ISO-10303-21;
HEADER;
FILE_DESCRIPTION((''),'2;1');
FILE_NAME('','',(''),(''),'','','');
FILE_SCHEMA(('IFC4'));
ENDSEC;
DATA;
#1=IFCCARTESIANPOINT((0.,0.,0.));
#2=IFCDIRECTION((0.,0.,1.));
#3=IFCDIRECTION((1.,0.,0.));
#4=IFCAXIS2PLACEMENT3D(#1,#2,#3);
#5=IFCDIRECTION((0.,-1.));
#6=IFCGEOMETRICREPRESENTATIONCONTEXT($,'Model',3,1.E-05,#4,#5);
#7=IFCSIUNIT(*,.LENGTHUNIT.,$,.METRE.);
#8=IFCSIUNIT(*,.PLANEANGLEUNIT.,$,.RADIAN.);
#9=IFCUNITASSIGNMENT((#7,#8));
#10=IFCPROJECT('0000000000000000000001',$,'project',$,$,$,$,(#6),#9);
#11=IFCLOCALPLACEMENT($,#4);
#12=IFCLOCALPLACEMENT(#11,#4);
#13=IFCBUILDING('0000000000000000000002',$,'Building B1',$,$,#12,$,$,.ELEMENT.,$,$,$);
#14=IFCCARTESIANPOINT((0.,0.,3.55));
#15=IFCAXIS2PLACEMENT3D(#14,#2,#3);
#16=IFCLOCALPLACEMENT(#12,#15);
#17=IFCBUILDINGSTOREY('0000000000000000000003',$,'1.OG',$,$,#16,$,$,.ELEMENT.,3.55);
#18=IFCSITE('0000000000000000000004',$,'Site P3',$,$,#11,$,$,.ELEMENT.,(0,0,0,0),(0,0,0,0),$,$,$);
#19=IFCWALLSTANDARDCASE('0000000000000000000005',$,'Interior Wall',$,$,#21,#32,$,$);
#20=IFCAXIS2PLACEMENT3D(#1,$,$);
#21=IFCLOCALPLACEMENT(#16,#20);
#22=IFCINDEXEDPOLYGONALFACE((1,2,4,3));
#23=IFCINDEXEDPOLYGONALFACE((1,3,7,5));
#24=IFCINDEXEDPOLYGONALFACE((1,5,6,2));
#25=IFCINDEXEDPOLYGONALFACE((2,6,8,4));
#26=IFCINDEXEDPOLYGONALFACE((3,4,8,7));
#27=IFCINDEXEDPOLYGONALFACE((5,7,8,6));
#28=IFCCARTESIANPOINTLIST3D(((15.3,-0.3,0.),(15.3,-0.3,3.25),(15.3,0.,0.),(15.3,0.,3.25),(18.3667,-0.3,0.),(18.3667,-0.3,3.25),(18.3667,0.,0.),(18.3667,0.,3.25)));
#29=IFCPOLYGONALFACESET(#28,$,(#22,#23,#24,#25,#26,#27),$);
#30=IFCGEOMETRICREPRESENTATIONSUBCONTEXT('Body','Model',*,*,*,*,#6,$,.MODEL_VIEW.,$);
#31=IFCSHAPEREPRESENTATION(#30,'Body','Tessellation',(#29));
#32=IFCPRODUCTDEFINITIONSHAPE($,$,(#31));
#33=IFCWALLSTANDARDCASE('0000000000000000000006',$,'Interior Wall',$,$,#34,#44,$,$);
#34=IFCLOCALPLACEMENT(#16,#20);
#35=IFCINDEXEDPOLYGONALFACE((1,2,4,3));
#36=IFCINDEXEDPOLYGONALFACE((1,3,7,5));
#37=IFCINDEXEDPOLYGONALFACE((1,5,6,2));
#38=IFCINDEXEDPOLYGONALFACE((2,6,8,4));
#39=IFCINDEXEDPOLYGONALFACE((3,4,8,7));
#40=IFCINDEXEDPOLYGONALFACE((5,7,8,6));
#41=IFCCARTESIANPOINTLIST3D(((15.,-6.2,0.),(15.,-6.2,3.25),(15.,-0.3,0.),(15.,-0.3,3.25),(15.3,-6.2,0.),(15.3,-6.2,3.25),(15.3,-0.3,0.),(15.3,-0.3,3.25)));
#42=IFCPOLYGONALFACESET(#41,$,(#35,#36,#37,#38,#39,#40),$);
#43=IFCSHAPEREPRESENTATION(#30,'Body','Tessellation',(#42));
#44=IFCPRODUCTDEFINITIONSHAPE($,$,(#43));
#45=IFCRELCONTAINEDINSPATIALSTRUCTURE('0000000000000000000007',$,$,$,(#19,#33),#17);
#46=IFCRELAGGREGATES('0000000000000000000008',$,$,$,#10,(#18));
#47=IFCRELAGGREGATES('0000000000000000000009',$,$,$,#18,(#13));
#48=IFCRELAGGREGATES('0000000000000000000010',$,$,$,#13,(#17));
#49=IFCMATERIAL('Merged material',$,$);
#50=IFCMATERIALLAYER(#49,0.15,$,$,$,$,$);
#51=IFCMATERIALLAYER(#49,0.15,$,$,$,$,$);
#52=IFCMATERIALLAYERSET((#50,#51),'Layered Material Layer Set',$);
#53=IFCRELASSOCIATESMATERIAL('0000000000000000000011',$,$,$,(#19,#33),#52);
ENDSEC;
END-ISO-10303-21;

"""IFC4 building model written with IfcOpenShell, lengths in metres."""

from ifc_helpers import new_model, si_unit, direction, frame, origin_with_axes, place, context, subcontext, project, spatial, polyline, outline, extrude, material, layer, layer_set, layer_usage, element, save


model = new_model("IFC4")

# Units and contexts
model_context = context("Model", 3, precision=1e-05, world=origin_with_axes(), true_north=direction((0.0, -1.0)))
body_context = subcontext(model_context, "Body", "Model", "MODEL_VIEW")
ifc_project = project(units=[si_unit("LENGTHUNIT", "METRE"), si_unit("PLANEANGLEUNIT", "RADIAN")], contexts=[model_context])

# Site, building, storey
site_placement = place(None, origin_with_axes())
site = spatial("IfcSite", under=ifc_project, at=site_placement, Name="Site P3", CompositionType="ELEMENT", RefLatitude=(0, 0, 0, 0), RefLongitude=(0, 0, 0, 0))
building_placement = place(site_placement, origin_with_axes())
building = spatial("IfcBuilding", under=site, at=building_placement, Name="Building B1", CompositionType="ELEMENT")
storey_placement = place(building_placement, frame((0.0, 0.0, 3.55), z_axis=(0.0, 0.0, 1.0), x_axis=(1.0, 0.0, 0.0)))
storey = spatial("IfcBuildingStorey", under=building, at=storey_placement, Name="1.OG", CompositionType="ELEMENT", Elevation=3.55)

# Shared definitions
ifc_material = material(Name="Merged material")

# Shared definitions
ifc_layer_1 = layer(ifc_material, 0.15)
ifc_layer_2 = layer(ifc_material, 0.15)
ifc_layer_set_1 = layer_set([ifc_layer_1, ifc_layer_2], Name="Layered Material Layer Set")
ifc_layer_usage_1 = layer_usage(ifc_layer_set_1, "AXIS2", "POSITIVE", -0.15)

# Walls
wall_1_placement = place(storey_placement, frame((15.3, -0.15, 0.0), z_axis=(0.0, 0.0, 1.0), x_axis=(1.0, 0.0, 0.0)))
element("IfcWallStandardCase", 1, at=wall_1_placement, inside=storey, material=ifc_layer_usage_1, Name="Interior Wall", context=body_context, shape_type="SweptSolid", body=[
    extrude(outline(polyline([(0.0, 0.15), (3.0667, 0.15), (3.0667, -0.15), (0.0, -0.15), (0.0, 0.15)])), origin_with_axes(), (0.0, 0.0, 1.0), 3.25),
])
wall_2_placement = place(storey_placement, frame((15.15, -0.3, 0.0), z_axis=(0.0, 0.0, 1.0), x_axis=(0.0, -1.0, 0.0)))
element("IfcWallStandardCase", 2, at=wall_2_placement, inside=storey, material=ifc_layer_usage_1, Name="Interior Wall", context=body_context, shape_type="SweptSolid", body=[
    extrude(outline(polyline([(0.0, 0.15), (5.9, 0.15), (5.9, -0.15), (0.0, -0.15), (0.0, 0.15)])), origin_with_axes(), (0.0, 0.0, 1.0), 3.25),
])

save(model, "model.ifc")
